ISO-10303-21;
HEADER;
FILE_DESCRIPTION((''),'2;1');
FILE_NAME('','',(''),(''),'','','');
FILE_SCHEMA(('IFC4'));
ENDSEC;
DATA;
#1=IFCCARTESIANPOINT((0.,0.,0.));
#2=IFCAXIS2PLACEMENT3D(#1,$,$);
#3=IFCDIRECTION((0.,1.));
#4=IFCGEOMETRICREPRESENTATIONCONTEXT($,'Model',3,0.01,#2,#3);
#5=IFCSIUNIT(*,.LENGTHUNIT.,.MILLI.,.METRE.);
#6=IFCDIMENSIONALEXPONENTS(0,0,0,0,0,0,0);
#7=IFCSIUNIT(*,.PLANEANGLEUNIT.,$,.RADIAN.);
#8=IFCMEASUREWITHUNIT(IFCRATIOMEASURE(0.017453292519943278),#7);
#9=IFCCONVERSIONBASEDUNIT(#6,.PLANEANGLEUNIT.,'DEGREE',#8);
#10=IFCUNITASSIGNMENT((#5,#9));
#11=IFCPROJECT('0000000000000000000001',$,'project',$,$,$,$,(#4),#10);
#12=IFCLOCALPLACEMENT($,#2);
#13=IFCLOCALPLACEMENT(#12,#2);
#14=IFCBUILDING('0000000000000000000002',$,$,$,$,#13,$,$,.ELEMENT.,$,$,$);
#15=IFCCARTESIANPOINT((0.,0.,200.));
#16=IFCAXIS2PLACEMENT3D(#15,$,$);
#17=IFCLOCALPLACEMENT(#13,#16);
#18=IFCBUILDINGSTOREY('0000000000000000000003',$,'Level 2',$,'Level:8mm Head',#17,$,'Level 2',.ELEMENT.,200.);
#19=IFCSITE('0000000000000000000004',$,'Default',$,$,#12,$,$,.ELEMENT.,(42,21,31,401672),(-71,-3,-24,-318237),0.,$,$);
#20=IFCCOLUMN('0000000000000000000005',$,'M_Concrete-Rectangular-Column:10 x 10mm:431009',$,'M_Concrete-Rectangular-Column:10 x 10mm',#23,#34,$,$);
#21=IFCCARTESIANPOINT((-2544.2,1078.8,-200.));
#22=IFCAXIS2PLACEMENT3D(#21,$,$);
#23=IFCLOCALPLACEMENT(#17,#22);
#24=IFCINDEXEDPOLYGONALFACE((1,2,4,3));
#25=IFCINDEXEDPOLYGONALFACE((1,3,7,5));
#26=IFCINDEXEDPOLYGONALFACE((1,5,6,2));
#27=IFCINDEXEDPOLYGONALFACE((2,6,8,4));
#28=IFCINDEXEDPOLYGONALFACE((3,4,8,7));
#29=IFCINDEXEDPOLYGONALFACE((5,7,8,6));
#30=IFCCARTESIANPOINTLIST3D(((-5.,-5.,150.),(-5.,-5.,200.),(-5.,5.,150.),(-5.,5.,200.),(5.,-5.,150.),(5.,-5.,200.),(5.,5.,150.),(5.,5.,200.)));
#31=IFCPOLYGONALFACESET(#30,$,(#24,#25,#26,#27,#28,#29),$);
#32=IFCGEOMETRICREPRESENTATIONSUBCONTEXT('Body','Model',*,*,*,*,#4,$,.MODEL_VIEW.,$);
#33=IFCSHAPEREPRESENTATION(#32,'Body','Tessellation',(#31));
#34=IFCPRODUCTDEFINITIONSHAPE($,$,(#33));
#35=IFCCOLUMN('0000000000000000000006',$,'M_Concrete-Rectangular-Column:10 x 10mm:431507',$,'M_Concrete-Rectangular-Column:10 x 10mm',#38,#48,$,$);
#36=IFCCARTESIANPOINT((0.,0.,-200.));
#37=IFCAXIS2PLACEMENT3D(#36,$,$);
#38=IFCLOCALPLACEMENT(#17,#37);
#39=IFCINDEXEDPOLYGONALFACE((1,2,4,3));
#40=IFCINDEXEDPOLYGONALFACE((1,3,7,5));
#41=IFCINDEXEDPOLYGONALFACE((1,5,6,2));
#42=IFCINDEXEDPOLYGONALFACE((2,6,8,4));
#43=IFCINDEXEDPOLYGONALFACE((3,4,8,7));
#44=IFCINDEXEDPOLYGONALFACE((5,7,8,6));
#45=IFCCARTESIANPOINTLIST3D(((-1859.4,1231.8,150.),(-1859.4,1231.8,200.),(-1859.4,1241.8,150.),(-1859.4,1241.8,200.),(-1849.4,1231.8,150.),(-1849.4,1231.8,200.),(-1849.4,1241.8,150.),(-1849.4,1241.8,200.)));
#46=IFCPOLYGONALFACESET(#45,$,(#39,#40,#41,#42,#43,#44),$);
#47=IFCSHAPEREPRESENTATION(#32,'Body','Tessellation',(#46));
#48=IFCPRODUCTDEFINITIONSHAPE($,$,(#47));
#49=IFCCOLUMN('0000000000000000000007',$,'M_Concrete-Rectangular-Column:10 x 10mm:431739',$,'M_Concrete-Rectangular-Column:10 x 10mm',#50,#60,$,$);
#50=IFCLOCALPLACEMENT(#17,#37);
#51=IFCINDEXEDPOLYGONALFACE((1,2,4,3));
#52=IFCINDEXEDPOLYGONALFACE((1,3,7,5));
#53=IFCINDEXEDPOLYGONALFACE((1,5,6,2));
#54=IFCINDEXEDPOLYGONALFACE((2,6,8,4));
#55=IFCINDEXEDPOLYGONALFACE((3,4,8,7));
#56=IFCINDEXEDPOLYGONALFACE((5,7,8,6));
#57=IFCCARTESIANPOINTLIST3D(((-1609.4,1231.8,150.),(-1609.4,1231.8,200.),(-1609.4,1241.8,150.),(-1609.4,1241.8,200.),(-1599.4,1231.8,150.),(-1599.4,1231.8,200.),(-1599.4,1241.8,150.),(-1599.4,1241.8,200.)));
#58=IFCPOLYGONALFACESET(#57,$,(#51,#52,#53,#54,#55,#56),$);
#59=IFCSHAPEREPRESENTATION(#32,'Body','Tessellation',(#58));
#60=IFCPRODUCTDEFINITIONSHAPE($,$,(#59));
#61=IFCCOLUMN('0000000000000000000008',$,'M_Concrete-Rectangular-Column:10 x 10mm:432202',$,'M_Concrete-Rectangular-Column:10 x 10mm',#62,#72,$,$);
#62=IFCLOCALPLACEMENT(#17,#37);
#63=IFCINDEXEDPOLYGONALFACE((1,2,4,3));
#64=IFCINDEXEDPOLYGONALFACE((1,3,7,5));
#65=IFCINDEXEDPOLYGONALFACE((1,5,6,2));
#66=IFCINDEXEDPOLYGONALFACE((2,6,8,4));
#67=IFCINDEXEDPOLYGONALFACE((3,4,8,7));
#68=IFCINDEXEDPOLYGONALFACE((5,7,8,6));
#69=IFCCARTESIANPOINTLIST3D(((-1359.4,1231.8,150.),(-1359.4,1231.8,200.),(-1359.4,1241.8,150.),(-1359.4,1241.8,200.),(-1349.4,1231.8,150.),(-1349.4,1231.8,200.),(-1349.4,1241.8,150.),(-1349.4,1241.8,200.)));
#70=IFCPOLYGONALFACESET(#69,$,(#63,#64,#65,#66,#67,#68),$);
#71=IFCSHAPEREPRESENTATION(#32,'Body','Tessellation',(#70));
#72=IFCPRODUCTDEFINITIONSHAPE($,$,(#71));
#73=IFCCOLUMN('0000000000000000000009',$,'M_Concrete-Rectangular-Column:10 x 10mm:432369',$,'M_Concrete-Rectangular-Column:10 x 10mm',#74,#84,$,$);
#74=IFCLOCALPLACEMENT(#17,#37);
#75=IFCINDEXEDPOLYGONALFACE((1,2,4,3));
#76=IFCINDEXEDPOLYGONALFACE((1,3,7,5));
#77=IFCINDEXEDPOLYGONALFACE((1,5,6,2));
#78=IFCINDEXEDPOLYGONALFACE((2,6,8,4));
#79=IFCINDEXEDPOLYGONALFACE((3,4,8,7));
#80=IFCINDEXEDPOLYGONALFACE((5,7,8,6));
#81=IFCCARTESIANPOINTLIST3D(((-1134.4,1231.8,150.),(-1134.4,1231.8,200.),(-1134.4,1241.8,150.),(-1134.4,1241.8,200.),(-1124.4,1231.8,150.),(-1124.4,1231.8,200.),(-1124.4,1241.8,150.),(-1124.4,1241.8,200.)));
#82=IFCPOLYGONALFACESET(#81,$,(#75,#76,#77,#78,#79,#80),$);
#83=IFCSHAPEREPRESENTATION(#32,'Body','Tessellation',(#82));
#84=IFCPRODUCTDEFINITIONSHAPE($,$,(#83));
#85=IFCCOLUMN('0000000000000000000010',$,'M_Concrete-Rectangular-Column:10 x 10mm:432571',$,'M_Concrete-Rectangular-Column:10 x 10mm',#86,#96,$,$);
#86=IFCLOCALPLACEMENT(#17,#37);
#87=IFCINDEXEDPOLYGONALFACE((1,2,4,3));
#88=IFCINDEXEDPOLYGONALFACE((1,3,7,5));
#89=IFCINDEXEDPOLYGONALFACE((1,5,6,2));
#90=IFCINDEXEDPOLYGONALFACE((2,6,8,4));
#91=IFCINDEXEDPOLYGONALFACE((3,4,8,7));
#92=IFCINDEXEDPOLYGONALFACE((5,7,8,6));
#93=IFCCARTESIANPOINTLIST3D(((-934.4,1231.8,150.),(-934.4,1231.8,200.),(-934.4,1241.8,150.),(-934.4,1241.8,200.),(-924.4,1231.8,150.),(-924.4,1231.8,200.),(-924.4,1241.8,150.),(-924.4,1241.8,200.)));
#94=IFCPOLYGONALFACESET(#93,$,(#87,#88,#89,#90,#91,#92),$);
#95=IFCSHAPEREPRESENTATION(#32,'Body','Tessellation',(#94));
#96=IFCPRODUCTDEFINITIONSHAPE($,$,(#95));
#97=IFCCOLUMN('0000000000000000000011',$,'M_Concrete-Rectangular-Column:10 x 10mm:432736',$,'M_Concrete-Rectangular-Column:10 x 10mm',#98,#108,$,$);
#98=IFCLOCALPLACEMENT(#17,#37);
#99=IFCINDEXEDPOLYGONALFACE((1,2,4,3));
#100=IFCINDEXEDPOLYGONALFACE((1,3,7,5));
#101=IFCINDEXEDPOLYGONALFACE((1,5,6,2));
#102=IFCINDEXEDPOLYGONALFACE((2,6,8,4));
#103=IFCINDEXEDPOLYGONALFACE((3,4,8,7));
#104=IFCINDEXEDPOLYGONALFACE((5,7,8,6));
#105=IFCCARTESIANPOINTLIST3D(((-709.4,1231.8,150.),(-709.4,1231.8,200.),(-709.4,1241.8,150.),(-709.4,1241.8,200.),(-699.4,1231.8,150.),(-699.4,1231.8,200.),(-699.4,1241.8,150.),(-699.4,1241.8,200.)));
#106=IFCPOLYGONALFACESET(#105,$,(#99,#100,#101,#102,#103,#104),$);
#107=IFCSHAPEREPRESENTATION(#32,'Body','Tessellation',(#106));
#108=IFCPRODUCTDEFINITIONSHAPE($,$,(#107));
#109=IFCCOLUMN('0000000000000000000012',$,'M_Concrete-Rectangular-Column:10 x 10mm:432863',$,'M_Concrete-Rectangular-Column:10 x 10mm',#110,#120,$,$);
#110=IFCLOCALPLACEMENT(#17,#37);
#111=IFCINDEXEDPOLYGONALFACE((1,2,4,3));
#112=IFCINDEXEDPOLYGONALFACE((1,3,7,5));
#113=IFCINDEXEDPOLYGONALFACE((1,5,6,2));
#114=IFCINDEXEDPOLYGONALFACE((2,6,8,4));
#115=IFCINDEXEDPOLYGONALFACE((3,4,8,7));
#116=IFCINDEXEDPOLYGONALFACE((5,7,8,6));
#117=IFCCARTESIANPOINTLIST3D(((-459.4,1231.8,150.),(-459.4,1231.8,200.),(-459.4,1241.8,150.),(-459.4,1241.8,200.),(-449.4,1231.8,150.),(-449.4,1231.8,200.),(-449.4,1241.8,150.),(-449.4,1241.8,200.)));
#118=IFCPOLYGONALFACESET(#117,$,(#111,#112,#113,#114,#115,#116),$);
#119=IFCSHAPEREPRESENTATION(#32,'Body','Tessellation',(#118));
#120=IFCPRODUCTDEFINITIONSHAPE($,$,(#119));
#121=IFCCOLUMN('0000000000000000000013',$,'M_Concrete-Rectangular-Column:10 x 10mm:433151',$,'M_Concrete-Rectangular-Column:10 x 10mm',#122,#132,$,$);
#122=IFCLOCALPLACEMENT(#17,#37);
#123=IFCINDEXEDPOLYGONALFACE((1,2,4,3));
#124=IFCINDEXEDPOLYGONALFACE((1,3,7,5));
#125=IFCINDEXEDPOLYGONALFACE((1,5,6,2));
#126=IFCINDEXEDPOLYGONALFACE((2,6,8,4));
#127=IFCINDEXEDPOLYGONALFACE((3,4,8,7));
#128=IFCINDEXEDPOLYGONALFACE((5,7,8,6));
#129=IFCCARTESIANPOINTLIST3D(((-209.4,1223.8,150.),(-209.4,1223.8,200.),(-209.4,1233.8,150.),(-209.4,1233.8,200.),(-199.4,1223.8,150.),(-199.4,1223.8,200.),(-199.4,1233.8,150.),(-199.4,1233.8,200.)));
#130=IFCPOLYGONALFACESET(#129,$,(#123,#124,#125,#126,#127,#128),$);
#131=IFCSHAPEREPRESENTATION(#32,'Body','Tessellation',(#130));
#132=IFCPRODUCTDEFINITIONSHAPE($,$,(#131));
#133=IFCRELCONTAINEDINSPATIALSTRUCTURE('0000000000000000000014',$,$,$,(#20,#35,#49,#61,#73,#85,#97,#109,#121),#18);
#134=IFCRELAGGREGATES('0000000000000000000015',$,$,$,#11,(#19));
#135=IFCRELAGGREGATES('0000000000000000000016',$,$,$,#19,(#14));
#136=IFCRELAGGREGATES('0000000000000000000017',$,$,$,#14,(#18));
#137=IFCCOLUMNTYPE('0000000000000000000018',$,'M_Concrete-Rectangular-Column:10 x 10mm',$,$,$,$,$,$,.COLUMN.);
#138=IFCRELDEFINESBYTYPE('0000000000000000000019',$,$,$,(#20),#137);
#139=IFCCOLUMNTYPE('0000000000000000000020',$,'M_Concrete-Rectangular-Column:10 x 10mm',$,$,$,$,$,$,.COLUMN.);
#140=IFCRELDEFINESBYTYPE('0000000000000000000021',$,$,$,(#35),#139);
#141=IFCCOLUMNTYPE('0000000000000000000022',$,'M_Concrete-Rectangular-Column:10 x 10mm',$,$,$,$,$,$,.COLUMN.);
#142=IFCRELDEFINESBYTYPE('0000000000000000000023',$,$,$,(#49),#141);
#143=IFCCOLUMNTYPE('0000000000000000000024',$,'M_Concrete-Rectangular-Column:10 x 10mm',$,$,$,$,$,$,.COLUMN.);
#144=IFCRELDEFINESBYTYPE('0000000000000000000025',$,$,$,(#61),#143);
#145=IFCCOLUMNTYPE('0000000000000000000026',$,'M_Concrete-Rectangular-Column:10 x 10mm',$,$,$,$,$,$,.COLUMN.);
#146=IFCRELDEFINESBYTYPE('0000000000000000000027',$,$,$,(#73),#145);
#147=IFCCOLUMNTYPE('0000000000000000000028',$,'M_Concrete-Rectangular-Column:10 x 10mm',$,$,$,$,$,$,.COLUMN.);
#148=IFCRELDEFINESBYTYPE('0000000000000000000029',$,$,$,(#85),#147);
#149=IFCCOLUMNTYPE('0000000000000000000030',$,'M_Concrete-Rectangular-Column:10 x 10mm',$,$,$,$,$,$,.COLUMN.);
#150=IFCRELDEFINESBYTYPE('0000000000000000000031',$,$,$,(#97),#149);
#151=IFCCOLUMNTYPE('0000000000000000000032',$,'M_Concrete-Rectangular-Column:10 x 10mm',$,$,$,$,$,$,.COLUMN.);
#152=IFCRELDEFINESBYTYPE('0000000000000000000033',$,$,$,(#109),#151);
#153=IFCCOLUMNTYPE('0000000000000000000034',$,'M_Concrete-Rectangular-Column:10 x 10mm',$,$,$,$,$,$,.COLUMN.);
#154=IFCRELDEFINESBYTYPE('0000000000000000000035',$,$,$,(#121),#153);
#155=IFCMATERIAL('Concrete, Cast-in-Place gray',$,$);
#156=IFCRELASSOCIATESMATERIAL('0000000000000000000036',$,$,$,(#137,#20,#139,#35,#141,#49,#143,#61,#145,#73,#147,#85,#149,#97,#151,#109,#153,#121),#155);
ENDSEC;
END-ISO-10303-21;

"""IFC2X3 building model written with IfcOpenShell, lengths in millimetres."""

from ifc_helpers import new_model, entity, si_unit, converted_unit, direction, frame, frame_2d, origin, origin_2d_with_axis, place, context, subcontext, project, spatial, rectangle, extrude, source, transform, mapped, material, type_object, type_shapes, element, save


model = new_model("IFC2X3")

# Units and contexts
model_context = context("Model", 3, precision=0.01, world=origin(), true_north=direction((0.0, 1.0)))
body_context = subcontext(model_context, "Body", "Model", "MODEL_VIEW")
ifc_project = project(units=[si_unit("LENGTHUNIT", "METRE", prefix="MILLI"), converted_unit("PLANEANGLEUNIT", "DEGREE", entity("IfcRatioMeasure", 0.017453292519943278), si_unit("PLANEANGLEUNIT", "RADIAN"), dimensions=[0, 0, 0, 0, 0, 0, 0])], contexts=[model_context])

# Site, building, storey
site_placement = place(None, origin())
site = spatial("IfcSite", under=ifc_project, at=site_placement, Name="Default", CompositionType="ELEMENT", RefLatitude=(42, 21, 31, 401672), RefLongitude=(-71, -3, -24, -318237), RefElevation=0.0)
building_placement = place(site_placement, origin())
building = spatial("IfcBuilding", under=site, at=building_placement, CompositionType="ELEMENT")
storey_placement = place(building_placement, frame((0.0, 0.0, 200.0)))
storey = spatial("IfcBuildingStorey", under=building, at=storey_placement, Name="Level 2", ObjectType="Level:8mm Head", LongName="Level 2", CompositionType="ELEMENT", Elevation=200.0)

# Columns
ifc_material = material(Name="Concrete, Cast-in-Place gray")
column_type_1 = type_object("IfcColumnType", Name="M_Concrete-Rectangular-Column:10 x 10mm", PredefinedType="COLUMN", material=ifc_material)
shared_shape_1 = source(origin(), body_context, "Body", "SweptSolid", [
    extrude(rectangle(XDim=10.0, YDim=10.0, at=origin_2d_with_axis()), frame((0.0, 0.0, 150.0), z_axis=(0.0, 0.0, 1.0), x_axis=(0.0, -1.0, 0.0)), (0.0, 0.0, 1.0), 50.0),
])
type_shapes(column_type_1, [shared_shape_1])
column_1_placement = place(storey_placement, frame((-2544.2, 1078.8, -200.0)))
element("IfcColumn", 1, at=column_1_placement, inside=storey, type_object=column_type_1, material=ifc_material, Name="M_Concrete-Rectangular-Column:10 x 10mm:431009", ObjectType="M_Concrete-Rectangular-Column:10 x 10mm", context=body_context, shape_type="MappedRepresentation", body=[
    mapped(shared_shape_1, transform((0.0, 0.0, 0.0), scale=1.0)),
])
column_type_2 = type_object("IfcColumnType", Name="M_Concrete-Rectangular-Column:10 x 10mm", PredefinedType="COLUMN", material=ifc_material)
shared_shape_2 = source(origin(), body_context, "Body", "SweptSolid", [
    extrude(rectangle(XDim=10.0, YDim=10.0, at=frame_2d((0.0, 0.0), x_axis=(1.0, 0.0))), frame((-1854.4, 1236.8, 150.0), z_axis=(0.0, 0.0, 1.0), x_axis=(0.0, -1.0, 0.0)), (0.0, 0.0, 1.0), 50.0),
])
type_shapes(column_type_2, [shared_shape_2])
column_2_placement = place(storey_placement, frame((0.0, 0.0, -200.0)))
element("IfcColumn", 2, at=column_2_placement, inside=storey, type_object=column_type_2, material=ifc_material, Name="M_Concrete-Rectangular-Column:10 x 10mm:431507", ObjectType="M_Concrete-Rectangular-Column:10 x 10mm", context=body_context, shape_type="MappedRepresentation", body=[
    mapped(shared_shape_2, transform((0.0, 0.0, 0.0), scale=1.0)),
])
column_type_3 = type_object("IfcColumnType", Name="M_Concrete-Rectangular-Column:10 x 10mm", PredefinedType="COLUMN", material=ifc_material)
shared_shape_3 = source(origin(), body_context, "Body", "SweptSolid", [
    extrude(rectangle(XDim=10.0, YDim=10.0, at=frame_2d((0.0, 0.0), x_axis=(1.0, 0.0))), frame((-1604.4, 1236.8, 150.0), z_axis=(0.0, 0.0, 1.0), x_axis=(0.0, -1.0, 0.0)), (0.0, 0.0, 1.0), 50.0),
])
type_shapes(column_type_3, [shared_shape_3])
column_3_placement = place(storey_placement, frame((0.0, 0.0, -200.0)))
element("IfcColumn", 3, at=column_3_placement, inside=storey, type_object=column_type_3, material=ifc_material, Name="M_Concrete-Rectangular-Column:10 x 10mm:431739", ObjectType="M_Concrete-Rectangular-Column:10 x 10mm", context=body_context, shape_type="MappedRepresentation", body=[
    mapped(shared_shape_3, transform((0.0, 0.0, 0.0), scale=1.0)),
])
column_type_4 = type_object("IfcColumnType", Name="M_Concrete-Rectangular-Column:10 x 10mm", PredefinedType="COLUMN", material=ifc_material)
shared_shape_4 = source(origin(), body_context, "Body", "SweptSolid", [
    extrude(rectangle(XDim=10.0, YDim=10.0, at=frame_2d((0.0, 0.0), x_axis=(1.0, 0.0))), frame((-1354.4, 1236.8, 150.0), z_axis=(0.0, 0.0, 1.0), x_axis=(0.0, -1.0, 0.0)), (0.0, 0.0, 1.0), 50.0),
])
type_shapes(column_type_4, [shared_shape_4])
column_4_placement = place(storey_placement, frame((0.0, 0.0, -200.0)))
element("IfcColumn", 4, at=column_4_placement, inside=storey, type_object=column_type_4, material=ifc_material, Name="M_Concrete-Rectangular-Column:10 x 10mm:432202", ObjectType="M_Concrete-Rectangular-Column:10 x 10mm", context=body_context, shape_type="MappedRepresentation", body=[
    mapped(shared_shape_4, transform((0.0, 0.0, 0.0), scale=1.0)),
])
column_type_5 = type_object("IfcColumnType", Name="M_Concrete-Rectangular-Column:10 x 10mm", PredefinedType="COLUMN", material=ifc_material)
shared_shape_5 = source(origin(), body_context, "Body", "SweptSolid", [
    extrude(rectangle(XDim=10.0, YDim=10.0, at=frame_2d((0.0, 0.0), x_axis=(1.0, 0.0))), frame((-1129.4, 1236.8, 150.0), z_axis=(0.0, 0.0, 1.0), x_axis=(0.0, -1.0, 0.0)), (0.0, 0.0, 1.0), 50.0),
])
type_shapes(column_type_5, [shared_shape_5])
column_5_placement = place(storey_placement, frame((0.0, 0.0, -200.0)))
element("IfcColumn", 5, at=column_5_placement, inside=storey, type_object=column_type_5, material=ifc_material, Name="M_Concrete-Rectangular-Column:10 x 10mm:432369", ObjectType="M_Concrete-Rectangular-Column:10 x 10mm", context=body_context, shape_type="MappedRepresentation", body=[
    mapped(shared_shape_5, transform((0.0, 0.0, 0.0), scale=1.0)),
])
column_type_6 = type_object("IfcColumnType", Name="M_Concrete-Rectangular-Column:10 x 10mm", PredefinedType="COLUMN", material=ifc_material)
shared_shape_6 = source(origin(), body_context, "Body", "SweptSolid", [
    extrude(rectangle(XDim=10.0, YDim=10.0, at=frame_2d((0.0, 0.0), x_axis=(1.0, 0.0))), frame((-929.4, 1236.8, 150.0), z_axis=(0.0, 0.0, 1.0), x_axis=(0.0, -1.0, 0.0)), (0.0, 0.0, 1.0), 50.0),
])
type_shapes(column_type_6, [shared_shape_6])
column_6_placement = place(storey_placement, frame((0.0, 0.0, -200.0)))
element("IfcColumn", 6, at=column_6_placement, inside=storey, type_object=column_type_6, material=ifc_material, Name="M_Concrete-Rectangular-Column:10 x 10mm:432571", ObjectType="M_Concrete-Rectangular-Column:10 x 10mm", context=body_context, shape_type="MappedRepresentation", body=[
    mapped(shared_shape_6, transform((0.0, 0.0, 0.0), scale=1.0)),
])
column_type_7 = type_object("IfcColumnType", Name="M_Concrete-Rectangular-Column:10 x 10mm", PredefinedType="COLUMN", material=ifc_material)
shared_shape_7 = source(origin(), body_context, "Body", "SweptSolid", [
    extrude(rectangle(XDim=10.0, YDim=10.0, at=frame_2d((0.0, 0.0), x_axis=(1.0, 0.0))), frame((-704.4, 1236.8, 150.0), z_axis=(0.0, 0.0, 1.0), x_axis=(0.0, -1.0, 0.0)), (0.0, 0.0, 1.0), 50.0),
])
type_shapes(column_type_7, [shared_shape_7])
column_7_placement = place(storey_placement, frame((0.0, 0.0, -200.0)))
element("IfcColumn", 7, at=column_7_placement, inside=storey, type_object=column_type_7, material=ifc_material, Name="M_Concrete-Rectangular-Column:10 x 10mm:432736", ObjectType="M_Concrete-Rectangular-Column:10 x 10mm", context=body_context, shape_type="MappedRepresentation", body=[
    mapped(shared_shape_7, transform((0.0, 0.0, 0.0), scale=1.0)),
])
column_type_8 = type_object("IfcColumnType", Name="M_Concrete-Rectangular-Column:10 x 10mm", PredefinedType="COLUMN", material=ifc_material)
shared_shape_8 = source(origin(), body_context, "Body", "SweptSolid", [
    extrude(rectangle(XDim=10.0, YDim=10.0, at=frame_2d((0.0, 0.0), x_axis=(1.0, 0.0))), frame((-454.4, 1236.8, 150.0), z_axis=(0.0, 0.0, 1.0), x_axis=(0.0, -1.0, 0.0)), (0.0, 0.0, 1.0), 50.0),
])
type_shapes(column_type_8, [shared_shape_8])
column_8_placement = place(storey_placement, frame((0.0, 0.0, -200.0)))
element("IfcColumn", 8, at=column_8_placement, inside=storey, type_object=column_type_8, material=ifc_material, Name="M_Concrete-Rectangular-Column:10 x 10mm:432863", ObjectType="M_Concrete-Rectangular-Column:10 x 10mm", context=body_context, shape_type="MappedRepresentation", body=[
    mapped(shared_shape_8, transform((0.0, 0.0, 0.0), scale=1.0)),
])
column_type_9 = type_object("IfcColumnType", Name="M_Concrete-Rectangular-Column:10 x 10mm", PredefinedType="COLUMN", material=ifc_material)
shared_shape_9 = source(origin(), body_context, "Body", "SweptSolid", [
    extrude(rectangle(XDim=10.0, YDim=10.0, at=frame_2d((0.0, 0.0), x_axis=(1.0, 0.0))), frame((-204.4, 1228.8, 150.0), z_axis=(0.0, 0.0, 1.0), x_axis=(0.0, -1.0, 0.0)), (0.0, 0.0, 1.0), 50.0),
])
type_shapes(column_type_9, [shared_shape_9])
column_9_placement = place(storey_placement, frame((0.0, 0.0, -200.0)))
element("IfcColumn", 9, at=column_9_placement, inside=storey, type_object=column_type_9, material=ifc_material, Name="M_Concrete-Rectangular-Column:10 x 10mm:433151", ObjectType="M_Concrete-Rectangular-Column:10 x 10mm", context=body_context, shape_type="MappedRepresentation", body=[
    mapped(shared_shape_9, transform((0.0, 0.0, 0.0), scale=1.0)),
])

save(model, "model.ifc")
